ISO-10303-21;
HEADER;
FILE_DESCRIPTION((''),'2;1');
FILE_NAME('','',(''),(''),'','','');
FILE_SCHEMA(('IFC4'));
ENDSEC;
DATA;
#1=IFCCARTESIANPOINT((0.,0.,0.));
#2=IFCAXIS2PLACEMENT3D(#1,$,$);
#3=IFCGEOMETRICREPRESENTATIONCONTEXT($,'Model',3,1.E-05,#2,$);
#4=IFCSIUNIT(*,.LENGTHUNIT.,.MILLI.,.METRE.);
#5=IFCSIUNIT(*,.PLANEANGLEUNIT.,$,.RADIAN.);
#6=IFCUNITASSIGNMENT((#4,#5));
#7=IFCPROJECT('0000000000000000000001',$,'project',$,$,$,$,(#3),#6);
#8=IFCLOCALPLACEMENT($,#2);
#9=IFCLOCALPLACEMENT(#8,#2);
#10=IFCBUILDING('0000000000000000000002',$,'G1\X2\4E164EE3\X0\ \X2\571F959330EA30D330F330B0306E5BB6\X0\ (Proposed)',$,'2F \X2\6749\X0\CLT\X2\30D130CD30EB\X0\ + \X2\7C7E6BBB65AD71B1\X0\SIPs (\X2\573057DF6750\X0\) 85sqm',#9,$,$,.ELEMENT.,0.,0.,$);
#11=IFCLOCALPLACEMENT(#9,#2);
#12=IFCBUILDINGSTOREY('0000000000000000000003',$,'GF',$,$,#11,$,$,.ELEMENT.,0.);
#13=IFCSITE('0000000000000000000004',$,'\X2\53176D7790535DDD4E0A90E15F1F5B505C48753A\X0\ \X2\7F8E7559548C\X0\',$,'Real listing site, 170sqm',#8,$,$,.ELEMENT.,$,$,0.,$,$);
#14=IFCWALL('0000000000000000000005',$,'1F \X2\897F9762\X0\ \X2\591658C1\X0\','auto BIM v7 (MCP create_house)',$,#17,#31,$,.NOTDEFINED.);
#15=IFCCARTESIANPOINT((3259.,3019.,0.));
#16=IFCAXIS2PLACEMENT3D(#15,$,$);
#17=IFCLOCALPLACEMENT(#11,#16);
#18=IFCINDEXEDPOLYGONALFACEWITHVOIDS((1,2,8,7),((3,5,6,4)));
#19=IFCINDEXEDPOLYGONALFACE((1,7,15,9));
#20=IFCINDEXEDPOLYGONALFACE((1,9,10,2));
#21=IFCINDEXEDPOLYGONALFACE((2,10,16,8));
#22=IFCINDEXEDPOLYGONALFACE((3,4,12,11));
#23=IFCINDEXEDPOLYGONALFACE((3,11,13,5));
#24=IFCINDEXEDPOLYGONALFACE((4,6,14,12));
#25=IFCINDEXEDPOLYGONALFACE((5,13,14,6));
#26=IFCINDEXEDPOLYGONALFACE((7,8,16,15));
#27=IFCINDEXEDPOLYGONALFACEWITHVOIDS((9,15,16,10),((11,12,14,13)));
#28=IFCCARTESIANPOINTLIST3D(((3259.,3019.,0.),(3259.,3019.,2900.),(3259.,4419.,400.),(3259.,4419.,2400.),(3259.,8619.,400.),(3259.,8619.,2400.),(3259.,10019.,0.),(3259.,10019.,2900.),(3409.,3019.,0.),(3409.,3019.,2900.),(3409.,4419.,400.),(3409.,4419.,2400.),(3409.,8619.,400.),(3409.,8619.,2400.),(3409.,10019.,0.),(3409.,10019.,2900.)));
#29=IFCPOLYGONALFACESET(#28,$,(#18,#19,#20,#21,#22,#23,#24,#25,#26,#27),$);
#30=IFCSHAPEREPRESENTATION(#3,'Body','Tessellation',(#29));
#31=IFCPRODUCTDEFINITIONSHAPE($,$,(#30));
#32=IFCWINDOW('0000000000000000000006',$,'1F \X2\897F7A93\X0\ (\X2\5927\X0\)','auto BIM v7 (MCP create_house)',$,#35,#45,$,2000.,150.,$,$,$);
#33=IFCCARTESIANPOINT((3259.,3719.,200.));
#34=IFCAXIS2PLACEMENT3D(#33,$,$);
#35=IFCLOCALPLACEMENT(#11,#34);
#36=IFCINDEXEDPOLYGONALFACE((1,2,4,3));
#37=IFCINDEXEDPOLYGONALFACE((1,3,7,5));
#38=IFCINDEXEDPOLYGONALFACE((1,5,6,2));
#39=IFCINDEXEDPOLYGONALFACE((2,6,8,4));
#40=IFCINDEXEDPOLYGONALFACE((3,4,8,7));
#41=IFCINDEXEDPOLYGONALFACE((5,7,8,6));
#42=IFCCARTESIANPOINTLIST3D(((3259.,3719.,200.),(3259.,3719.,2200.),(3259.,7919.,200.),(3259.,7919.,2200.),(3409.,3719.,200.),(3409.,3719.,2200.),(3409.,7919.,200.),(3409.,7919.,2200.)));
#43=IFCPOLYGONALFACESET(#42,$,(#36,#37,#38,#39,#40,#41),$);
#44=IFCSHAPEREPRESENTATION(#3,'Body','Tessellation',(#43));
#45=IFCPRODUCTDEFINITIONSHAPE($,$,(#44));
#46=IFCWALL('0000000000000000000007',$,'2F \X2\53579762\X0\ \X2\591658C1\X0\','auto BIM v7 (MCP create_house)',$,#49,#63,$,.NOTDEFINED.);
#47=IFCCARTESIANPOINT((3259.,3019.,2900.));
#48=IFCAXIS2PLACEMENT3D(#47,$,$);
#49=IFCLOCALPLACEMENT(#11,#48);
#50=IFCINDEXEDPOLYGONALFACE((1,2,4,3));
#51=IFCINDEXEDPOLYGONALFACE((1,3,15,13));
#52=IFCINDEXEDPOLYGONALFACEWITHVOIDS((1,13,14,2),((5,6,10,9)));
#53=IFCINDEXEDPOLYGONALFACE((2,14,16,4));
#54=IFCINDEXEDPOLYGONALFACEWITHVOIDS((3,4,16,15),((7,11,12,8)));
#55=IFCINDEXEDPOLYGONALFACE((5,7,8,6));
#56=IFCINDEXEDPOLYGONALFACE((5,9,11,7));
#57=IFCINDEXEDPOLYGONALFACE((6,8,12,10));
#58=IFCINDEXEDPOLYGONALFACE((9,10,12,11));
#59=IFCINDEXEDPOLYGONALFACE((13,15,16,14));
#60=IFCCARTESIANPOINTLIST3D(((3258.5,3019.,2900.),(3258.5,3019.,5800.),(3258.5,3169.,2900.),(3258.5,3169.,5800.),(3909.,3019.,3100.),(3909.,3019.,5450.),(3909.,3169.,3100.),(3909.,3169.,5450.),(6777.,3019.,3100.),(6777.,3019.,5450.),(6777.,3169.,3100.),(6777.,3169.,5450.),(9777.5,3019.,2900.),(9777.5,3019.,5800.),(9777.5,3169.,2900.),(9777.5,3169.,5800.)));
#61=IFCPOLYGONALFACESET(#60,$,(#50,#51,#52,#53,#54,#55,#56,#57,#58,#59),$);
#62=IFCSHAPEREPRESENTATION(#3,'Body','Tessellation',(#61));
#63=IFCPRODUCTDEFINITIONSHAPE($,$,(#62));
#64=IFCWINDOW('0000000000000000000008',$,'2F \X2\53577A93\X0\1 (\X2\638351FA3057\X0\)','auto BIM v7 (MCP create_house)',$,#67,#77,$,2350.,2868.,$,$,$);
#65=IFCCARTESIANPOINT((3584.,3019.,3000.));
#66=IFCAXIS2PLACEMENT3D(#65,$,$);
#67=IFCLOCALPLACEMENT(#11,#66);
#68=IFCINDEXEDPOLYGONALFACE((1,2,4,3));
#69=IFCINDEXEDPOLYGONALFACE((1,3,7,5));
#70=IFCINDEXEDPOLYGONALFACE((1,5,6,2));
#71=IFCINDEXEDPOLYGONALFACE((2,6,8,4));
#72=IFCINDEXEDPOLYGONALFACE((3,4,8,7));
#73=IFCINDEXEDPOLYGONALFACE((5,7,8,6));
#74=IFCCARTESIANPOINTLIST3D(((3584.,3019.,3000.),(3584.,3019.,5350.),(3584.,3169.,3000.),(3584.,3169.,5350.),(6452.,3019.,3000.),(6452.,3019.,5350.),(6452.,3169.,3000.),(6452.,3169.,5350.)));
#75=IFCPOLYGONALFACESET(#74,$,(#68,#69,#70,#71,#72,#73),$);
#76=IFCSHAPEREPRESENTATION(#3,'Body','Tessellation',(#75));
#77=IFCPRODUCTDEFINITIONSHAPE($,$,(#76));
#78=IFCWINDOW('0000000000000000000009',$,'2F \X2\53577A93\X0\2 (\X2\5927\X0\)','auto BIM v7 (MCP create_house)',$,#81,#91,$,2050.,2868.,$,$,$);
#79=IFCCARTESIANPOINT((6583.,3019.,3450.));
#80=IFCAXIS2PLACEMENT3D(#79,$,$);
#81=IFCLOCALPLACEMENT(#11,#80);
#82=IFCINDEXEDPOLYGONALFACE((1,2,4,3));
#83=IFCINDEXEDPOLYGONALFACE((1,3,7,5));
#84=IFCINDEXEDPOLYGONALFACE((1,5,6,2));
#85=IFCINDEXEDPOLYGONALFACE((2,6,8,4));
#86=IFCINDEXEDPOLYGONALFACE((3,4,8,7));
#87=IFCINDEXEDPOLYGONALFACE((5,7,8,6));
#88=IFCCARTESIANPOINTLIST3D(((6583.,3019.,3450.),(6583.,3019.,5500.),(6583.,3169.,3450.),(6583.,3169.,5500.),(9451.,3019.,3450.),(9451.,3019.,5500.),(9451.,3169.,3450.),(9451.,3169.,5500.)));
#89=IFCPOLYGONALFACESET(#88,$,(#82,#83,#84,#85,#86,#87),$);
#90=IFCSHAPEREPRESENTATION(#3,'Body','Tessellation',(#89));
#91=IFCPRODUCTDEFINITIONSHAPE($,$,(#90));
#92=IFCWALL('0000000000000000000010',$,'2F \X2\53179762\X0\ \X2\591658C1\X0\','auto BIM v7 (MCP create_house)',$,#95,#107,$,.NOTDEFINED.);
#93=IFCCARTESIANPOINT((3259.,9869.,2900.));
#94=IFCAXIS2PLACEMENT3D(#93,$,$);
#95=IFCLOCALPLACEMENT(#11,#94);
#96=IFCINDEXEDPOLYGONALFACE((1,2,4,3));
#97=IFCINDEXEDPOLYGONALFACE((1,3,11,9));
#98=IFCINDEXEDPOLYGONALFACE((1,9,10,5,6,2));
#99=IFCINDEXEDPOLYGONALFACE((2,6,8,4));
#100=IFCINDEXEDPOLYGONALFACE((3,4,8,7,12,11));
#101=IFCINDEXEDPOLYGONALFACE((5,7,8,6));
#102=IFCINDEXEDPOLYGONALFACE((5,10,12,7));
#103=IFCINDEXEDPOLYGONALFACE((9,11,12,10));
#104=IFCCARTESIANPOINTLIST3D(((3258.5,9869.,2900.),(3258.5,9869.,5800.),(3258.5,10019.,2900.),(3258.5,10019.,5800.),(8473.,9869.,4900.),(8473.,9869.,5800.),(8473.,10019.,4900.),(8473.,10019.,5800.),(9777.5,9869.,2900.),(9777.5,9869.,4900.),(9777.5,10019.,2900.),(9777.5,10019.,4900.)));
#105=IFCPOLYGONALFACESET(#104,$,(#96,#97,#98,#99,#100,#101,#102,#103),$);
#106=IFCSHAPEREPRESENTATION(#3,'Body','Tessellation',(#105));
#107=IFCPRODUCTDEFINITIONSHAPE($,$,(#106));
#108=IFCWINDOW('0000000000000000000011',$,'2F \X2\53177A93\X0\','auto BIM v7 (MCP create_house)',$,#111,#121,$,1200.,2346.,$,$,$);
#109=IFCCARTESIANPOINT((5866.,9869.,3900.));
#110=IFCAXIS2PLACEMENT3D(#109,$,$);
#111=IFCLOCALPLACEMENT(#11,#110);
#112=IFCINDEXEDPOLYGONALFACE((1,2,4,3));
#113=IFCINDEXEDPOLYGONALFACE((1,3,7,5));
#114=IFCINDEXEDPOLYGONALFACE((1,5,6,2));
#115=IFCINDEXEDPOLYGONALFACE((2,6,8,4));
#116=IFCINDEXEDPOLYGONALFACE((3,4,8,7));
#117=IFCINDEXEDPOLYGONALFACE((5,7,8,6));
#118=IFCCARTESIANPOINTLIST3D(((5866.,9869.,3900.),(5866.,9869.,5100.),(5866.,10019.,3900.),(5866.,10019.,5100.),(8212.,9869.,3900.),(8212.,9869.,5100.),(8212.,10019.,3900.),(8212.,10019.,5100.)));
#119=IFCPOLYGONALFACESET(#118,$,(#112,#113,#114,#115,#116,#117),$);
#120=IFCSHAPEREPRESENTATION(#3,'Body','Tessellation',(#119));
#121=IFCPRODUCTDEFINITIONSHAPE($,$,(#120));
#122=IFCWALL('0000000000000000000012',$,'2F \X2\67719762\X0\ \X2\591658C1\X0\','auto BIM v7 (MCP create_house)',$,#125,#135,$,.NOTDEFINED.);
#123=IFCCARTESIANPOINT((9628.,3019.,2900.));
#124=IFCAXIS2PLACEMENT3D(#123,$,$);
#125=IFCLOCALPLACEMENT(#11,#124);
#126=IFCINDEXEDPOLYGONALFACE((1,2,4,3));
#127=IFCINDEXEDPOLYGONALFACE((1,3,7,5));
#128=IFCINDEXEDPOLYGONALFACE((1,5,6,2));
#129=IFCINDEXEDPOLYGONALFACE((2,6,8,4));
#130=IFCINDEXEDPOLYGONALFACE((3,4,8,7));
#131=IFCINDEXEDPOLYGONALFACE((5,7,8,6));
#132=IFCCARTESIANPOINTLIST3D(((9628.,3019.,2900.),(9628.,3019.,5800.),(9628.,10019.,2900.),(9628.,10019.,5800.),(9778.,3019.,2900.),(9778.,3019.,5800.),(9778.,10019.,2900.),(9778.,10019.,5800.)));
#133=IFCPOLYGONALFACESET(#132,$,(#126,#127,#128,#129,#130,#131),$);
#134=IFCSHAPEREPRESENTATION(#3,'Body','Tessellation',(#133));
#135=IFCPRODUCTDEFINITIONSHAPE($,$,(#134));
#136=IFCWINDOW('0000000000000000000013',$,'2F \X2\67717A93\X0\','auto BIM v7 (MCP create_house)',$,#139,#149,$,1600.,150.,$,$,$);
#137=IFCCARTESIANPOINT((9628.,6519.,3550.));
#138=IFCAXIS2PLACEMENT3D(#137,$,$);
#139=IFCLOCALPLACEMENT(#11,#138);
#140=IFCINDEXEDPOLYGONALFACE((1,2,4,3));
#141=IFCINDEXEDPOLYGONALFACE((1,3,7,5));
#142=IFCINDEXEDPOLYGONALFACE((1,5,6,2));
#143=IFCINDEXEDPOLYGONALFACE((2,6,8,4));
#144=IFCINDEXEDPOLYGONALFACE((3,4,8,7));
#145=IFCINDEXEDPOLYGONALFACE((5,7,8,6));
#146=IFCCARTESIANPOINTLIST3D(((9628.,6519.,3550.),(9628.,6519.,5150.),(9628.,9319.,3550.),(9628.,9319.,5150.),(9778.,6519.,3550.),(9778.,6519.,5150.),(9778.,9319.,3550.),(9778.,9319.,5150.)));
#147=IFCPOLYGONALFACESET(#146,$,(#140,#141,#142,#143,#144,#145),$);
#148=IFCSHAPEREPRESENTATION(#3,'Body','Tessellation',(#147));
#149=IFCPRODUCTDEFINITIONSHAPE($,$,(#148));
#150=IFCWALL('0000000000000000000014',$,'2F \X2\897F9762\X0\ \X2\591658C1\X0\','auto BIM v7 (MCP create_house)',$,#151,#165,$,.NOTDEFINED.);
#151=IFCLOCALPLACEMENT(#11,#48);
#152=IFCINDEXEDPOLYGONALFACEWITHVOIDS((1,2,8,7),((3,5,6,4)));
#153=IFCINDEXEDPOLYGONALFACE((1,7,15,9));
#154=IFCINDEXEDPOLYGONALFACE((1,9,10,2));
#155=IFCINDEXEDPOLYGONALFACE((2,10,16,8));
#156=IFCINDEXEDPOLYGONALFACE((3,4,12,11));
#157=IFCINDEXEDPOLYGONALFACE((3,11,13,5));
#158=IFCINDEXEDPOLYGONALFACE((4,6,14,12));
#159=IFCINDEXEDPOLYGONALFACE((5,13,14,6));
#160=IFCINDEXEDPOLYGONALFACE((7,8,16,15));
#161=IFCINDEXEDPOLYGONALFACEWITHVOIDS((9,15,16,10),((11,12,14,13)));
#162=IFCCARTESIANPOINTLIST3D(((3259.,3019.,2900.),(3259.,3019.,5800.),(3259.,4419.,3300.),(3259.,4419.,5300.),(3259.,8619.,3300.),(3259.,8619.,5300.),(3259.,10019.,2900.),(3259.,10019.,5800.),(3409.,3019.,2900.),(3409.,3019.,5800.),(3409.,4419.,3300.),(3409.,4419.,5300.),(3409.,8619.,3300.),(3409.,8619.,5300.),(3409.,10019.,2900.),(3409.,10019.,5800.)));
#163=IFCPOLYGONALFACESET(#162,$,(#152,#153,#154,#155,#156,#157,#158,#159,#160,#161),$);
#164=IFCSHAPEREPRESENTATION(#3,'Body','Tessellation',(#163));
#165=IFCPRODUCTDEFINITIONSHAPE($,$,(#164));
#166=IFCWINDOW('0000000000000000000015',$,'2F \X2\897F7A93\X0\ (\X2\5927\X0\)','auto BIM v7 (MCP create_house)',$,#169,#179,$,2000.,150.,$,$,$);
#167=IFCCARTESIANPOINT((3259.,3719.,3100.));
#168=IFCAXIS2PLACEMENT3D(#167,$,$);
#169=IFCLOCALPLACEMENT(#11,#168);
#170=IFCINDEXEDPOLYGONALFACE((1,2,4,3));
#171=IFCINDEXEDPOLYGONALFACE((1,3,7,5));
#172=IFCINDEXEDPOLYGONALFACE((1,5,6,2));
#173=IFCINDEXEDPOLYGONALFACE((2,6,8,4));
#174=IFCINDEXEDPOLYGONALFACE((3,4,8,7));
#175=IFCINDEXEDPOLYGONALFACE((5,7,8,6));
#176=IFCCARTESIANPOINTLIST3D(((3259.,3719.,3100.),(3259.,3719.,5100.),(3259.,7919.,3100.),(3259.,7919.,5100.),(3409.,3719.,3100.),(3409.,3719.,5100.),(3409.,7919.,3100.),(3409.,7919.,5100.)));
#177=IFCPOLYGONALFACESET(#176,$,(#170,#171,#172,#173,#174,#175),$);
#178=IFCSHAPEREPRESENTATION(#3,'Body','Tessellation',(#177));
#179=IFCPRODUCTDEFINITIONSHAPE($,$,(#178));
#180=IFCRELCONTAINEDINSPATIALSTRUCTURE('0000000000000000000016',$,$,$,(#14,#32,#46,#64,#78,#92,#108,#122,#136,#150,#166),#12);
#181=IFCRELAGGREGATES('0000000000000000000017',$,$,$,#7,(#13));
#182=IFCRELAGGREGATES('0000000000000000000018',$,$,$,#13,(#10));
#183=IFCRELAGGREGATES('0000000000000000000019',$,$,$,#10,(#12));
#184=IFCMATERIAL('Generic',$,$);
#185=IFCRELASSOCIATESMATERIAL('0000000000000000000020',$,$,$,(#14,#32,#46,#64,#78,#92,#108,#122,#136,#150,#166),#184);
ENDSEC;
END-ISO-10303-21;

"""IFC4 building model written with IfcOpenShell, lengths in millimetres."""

from ifc_helpers import new_model, si_unit, frame, frame_2d, origin, place, context, project, spatial, rectangle, extrude, material, element, fill, save


model = new_model("IFC4")

# Units and contexts
model_context = context("Model", 3, precision=1e-05, world=origin())
ifc_project = project(units=[si_unit("LENGTHUNIT", "METRE", prefix="MILLI"), si_unit("PLANEANGLEUNIT", "RADIAN")], contexts=[model_context])

# Site, building, storey
site_placement = place(None, origin())
site = spatial("IfcSite", under=ifc_project, at=site_placement, Name="北海道川上郡弟子屈町 美留和", ObjectType="Real listing site, 170sqm", CompositionType="ELEMENT", RefElevation=0.0)
building_placement = place(site_placement, origin())
building = spatial("IfcBuilding", under=site, at=building_placement, Name="G1世代 土間リビングの家 (Proposed)", ObjectType="2F 杉CLTパネル + 籾殻断熱SIPs (地域材) 85sqm", CompositionType="ELEMENT", ElevationOfRefHeight=0.0, ElevationOfTerrain=0.0)
storey_placement = place(building_placement, origin())
storey = spatial("IfcBuildingStorey", under=building, at=storey_placement, Name="GF", CompositionType="ELEMENT", Elevation=0.0)

# Shared definitions
ifc_material = material(Name="Generic")

# Wall, opening, window
wall_1_placement = place(storey_placement, frame((3259.0, 3019.0, 0.0)))
wall_1 = element("IfcWall", 1, at=wall_1_placement, inside=storey, material=ifc_material, Name="1F 西面 外壁", Description="auto BIM v7 (MCP create_house)", PredefinedType="NOTDEFINED", context=model_context, shape_type="SweptSolid", body=[
    extrude(rectangle(XDim=150.0, YDim=7000.0, at=frame_2d((75.0, 3500.0))), frame((3259.0, 3019.0, 0.0)), (0.0, 0.0, 1.0), 2900.0),
])
opening_1_placement = place(storey_placement, frame((3259.0, 3719.0, 200.0)))
opening_1 = element("IfcOpeningElement", 2, at=opening_1_placement, cuts=wall_1, PredefinedType="NOTDEFINED", context=model_context, shape_type="SweptSolid", body=[
    extrude(rectangle(XDim=150.0, YDim=4200.0, at=frame_2d((75.0, 2100.0))), frame((3259.0, 3719.0, 200.0)), (0.0, 0.0, 1.0), 2000.0),
])
window_1_placement = place(storey_placement, frame((3259.0, 3719.0, 200.0)))
window_1 = element("IfcWindow", 3, at=window_1_placement, inside=storey, material=ifc_material, Name="1F 西窓 (大)", Description="auto BIM v7 (MCP create_house)", OverallHeight=2000.0, OverallWidth=150.0, context=model_context, shape_type="SweptSolid", body=[
    extrude(rectangle(XDim=150.0, YDim=4200.0, at=frame_2d((75.0, 2100.0))), frame((3259.0, 3719.0, 200.0)), (0.0, 0.0, 1.0), 2000.0),
])
fill(opening_1, window_1)

# Wall, openings, windows
wall_2_placement = place(storey_placement, frame((3259.0, 3019.0, 2900.0)))
wall_2 = element("IfcWall", 4, at=wall_2_placement, inside=storey, material=ifc_material, Name="2F 南面 外壁", Description="auto BIM v7 (MCP create_house)", PredefinedType="NOTDEFINED", context=model_context, shape_type="SweptSolid", body=[
    extrude(rectangle(XDim=6519.0, YDim=150.0, at=frame_2d((3259.0, 75.0))), frame((3259.0, 3019.0, 2900.0)), (0.0, 0.0, 1.0), 2900.0),
])
opening_2_placement = place(storey_placement, frame((3584.0, 3019.0, 3000.0)))
opening_2 = element("IfcOpeningElement", 5, at=opening_2_placement, cuts=wall_2, PredefinedType="NOTDEFINED", context=model_context, shape_type="SweptSolid", body=[
    extrude(rectangle(XDim=2868.0, YDim=150.0, at=frame_2d((1434.0, 75.0))), frame((3584.0, 3019.0, 3000.0)), (0.0, 0.0, 1.0), 2350.0),
])
opening_3_placement = place(storey_placement, frame((6583.0, 3019.0, 3450.0)))
opening_3 = element("IfcOpeningElement", 6, at=opening_3_placement, cuts=wall_2, PredefinedType="NOTDEFINED", context=model_context, shape_type="SweptSolid", body=[
    extrude(rectangle(XDim=2868.0, YDim=150.0, at=frame_2d((1434.0, 75.0))), frame((6583.0, 3019.0, 3450.0)), (0.0, 0.0, 1.0), 2050.0),
])
window_2_placement = place(storey_placement, frame((3584.0, 3019.0, 3000.0)))
window_2 = element("IfcWindow", 7, at=window_2_placement, inside=storey, material=ifc_material, Name="2F 南窓1 (掃出し)", Description="auto BIM v7 (MCP create_house)", OverallHeight=2350.0, OverallWidth=2868.0, context=model_context, shape_type="SweptSolid", body=[
    extrude(rectangle(XDim=2868.0, YDim=150.0, at=frame_2d((1434.0, 75.0))), frame((3584.0, 3019.0, 3000.0)), (0.0, 0.0, 1.0), 2350.0),
])
fill(opening_2, window_2)
window_3_placement = place(storey_placement, frame((6583.0, 3019.0, 3450.0)))
window_3 = element("IfcWindow", 8, at=window_3_placement, inside=storey, material=ifc_material, Name="2F 南窓2 (大)", Description="auto BIM v7 (MCP create_house)", OverallHeight=2050.0, OverallWidth=2868.0, context=model_context, shape_type="SweptSolid", body=[
    extrude(rectangle(XDim=2868.0, YDim=150.0, at=frame_2d((1434.0, 75.0))), frame((6583.0, 3019.0, 3450.0)), (0.0, 0.0, 1.0), 2050.0),
])
fill(opening_3, window_3)

# Walls, openings, windows
wall_3_placement = place(storey_placement, frame((3259.0, 9869.0, 2900.0)))
wall_3 = element("IfcWall", 9, at=wall_3_placement, inside=storey, material=ifc_material, Name="2F 北面 外壁", Description="auto BIM v7 (MCP create_house)", PredefinedType="NOTDEFINED", context=model_context, shape_type="SweptSolid", body=[
    extrude(rectangle(XDim=6519.0, YDim=150.0, at=frame_2d((3259.0, 75.0))), frame((3259.0, 9869.0, 2900.0)), (0.0, 0.0, 1.0), 2900.0),
])
opening_4_placement = place(storey_placement, frame((5866.0, 9869.0, 3900.0)))
opening_4 = element("IfcOpeningElement", 10, at=opening_4_placement, cuts=wall_3, PredefinedType="NOTDEFINED", context=model_context, shape_type="SweptSolid", body=[
    extrude(rectangle(XDim=2346.0, YDim=150.0, at=frame_2d((1173.0, 75.0))), frame((5866.0, 9869.0, 3900.0)), (0.0, 0.0, 1.0), 1200.0),
])
window_4_placement = place(storey_placement, frame((5866.0, 9869.0, 3900.0)))
window_4 = element("IfcWindow", 11, at=window_4_placement, inside=storey, material=ifc_material, Name="2F 北窓", Description="auto BIM v7 (MCP create_house)", OverallHeight=1200.0, OverallWidth=2346.0, context=model_context, shape_type="SweptSolid", body=[
    extrude(rectangle(XDim=2346.0, YDim=150.0, at=frame_2d((1173.0, 75.0))), frame((5866.0, 9869.0, 3900.0)), (0.0, 0.0, 1.0), 1200.0),
])
fill(opening_4, window_4)
wall_4_placement = place(storey_placement, frame((9628.0, 3019.0, 2900.0)))
wall_4 = element("IfcWall", 12, at=wall_4_placement, inside=storey, material=ifc_material, Name="2F 東面 外壁", Description="auto BIM v7 (MCP create_house)", PredefinedType="NOTDEFINED", context=model_context, shape_type="SweptSolid", body=[
    extrude(rectangle(XDim=150.0, YDim=7000.0, at=frame_2d((75.0, 3500.0))), frame((9628.0, 3019.0, 2900.0)), (0.0, 0.0, 1.0), 2900.0),
])
opening_5_placement = place(storey_placement, frame((9628.0, 6519.0, 3550.0)))
opening_5 = element("IfcOpeningElement", 13, at=opening_5_placement, cuts=wall_4, PredefinedType="NOTDEFINED", context=model_context, shape_type="SweptSolid", body=[
    extrude(rectangle(XDim=150.0, YDim=2800.0, at=frame_2d((75.0, 1400.0))), frame((9628.0, 6519.0, 3550.0)), (0.0, 0.0, 1.0), 1600.0),
])
window_5_placement = place(storey_placement, frame((9628.0, 6519.0, 3550.0)))
window_5 = element("IfcWindow", 14, at=window_5_placement, inside=storey, material=ifc_material, Name="2F 東窓", Description="auto BIM v7 (MCP create_house)", OverallHeight=1600.0, OverallWidth=150.0, context=model_context, shape_type="SweptSolid", body=[
    extrude(rectangle(XDim=150.0, YDim=2800.0, at=frame_2d((75.0, 1400.0))), frame((9628.0, 6519.0, 3550.0)), (0.0, 0.0, 1.0), 1600.0),
])
fill(opening_5, window_5)
wall_5_placement = place(storey_placement, frame((3259.0, 3019.0, 2900.0)))
wall_5 = element("IfcWall", 15, at=wall_5_placement, inside=storey, material=ifc_material, Name="2F 西面 外壁", Description="auto BIM v7 (MCP create_house)", PredefinedType="NOTDEFINED", context=model_context, shape_type="SweptSolid", body=[
    extrude(rectangle(XDim=150.0, YDim=7000.0, at=frame_2d((75.0, 3500.0))), frame((3259.0, 3019.0, 2900.0)), (0.0, 0.0, 1.0), 2900.0),
])
opening_6_placement = place(storey_placement, frame((3259.0, 3719.0, 3100.0)))
opening_6 = element("IfcOpeningElement", 16, at=opening_6_placement, cuts=wall_5, PredefinedType="NOTDEFINED", context=model_context, shape_type="SweptSolid", body=[
    extrude(rectangle(XDim=150.0, YDim=4200.0, at=frame_2d((75.0, 2100.0))), frame((3259.0, 3719.0, 3100.0)), (0.0, 0.0, 1.0), 2000.0),
])
window_6_placement = place(storey_placement, frame((3259.0, 3719.0, 3100.0)))
window_6 = element("IfcWindow", 17, at=window_6_placement, inside=storey, material=ifc_material, Name="2F 西窓 (大)", Description="auto BIM v7 (MCP create_house)", OverallHeight=2000.0, OverallWidth=150.0, context=model_context, shape_type="SweptSolid", body=[
    extrude(rectangle(XDim=150.0, YDim=4200.0, at=frame_2d((75.0, 2100.0))), frame((3259.0, 3719.0, 3100.0)), (0.0, 0.0, 1.0), 2000.0),
])
fill(opening_6, window_6)

save(model, "model.ifc")
